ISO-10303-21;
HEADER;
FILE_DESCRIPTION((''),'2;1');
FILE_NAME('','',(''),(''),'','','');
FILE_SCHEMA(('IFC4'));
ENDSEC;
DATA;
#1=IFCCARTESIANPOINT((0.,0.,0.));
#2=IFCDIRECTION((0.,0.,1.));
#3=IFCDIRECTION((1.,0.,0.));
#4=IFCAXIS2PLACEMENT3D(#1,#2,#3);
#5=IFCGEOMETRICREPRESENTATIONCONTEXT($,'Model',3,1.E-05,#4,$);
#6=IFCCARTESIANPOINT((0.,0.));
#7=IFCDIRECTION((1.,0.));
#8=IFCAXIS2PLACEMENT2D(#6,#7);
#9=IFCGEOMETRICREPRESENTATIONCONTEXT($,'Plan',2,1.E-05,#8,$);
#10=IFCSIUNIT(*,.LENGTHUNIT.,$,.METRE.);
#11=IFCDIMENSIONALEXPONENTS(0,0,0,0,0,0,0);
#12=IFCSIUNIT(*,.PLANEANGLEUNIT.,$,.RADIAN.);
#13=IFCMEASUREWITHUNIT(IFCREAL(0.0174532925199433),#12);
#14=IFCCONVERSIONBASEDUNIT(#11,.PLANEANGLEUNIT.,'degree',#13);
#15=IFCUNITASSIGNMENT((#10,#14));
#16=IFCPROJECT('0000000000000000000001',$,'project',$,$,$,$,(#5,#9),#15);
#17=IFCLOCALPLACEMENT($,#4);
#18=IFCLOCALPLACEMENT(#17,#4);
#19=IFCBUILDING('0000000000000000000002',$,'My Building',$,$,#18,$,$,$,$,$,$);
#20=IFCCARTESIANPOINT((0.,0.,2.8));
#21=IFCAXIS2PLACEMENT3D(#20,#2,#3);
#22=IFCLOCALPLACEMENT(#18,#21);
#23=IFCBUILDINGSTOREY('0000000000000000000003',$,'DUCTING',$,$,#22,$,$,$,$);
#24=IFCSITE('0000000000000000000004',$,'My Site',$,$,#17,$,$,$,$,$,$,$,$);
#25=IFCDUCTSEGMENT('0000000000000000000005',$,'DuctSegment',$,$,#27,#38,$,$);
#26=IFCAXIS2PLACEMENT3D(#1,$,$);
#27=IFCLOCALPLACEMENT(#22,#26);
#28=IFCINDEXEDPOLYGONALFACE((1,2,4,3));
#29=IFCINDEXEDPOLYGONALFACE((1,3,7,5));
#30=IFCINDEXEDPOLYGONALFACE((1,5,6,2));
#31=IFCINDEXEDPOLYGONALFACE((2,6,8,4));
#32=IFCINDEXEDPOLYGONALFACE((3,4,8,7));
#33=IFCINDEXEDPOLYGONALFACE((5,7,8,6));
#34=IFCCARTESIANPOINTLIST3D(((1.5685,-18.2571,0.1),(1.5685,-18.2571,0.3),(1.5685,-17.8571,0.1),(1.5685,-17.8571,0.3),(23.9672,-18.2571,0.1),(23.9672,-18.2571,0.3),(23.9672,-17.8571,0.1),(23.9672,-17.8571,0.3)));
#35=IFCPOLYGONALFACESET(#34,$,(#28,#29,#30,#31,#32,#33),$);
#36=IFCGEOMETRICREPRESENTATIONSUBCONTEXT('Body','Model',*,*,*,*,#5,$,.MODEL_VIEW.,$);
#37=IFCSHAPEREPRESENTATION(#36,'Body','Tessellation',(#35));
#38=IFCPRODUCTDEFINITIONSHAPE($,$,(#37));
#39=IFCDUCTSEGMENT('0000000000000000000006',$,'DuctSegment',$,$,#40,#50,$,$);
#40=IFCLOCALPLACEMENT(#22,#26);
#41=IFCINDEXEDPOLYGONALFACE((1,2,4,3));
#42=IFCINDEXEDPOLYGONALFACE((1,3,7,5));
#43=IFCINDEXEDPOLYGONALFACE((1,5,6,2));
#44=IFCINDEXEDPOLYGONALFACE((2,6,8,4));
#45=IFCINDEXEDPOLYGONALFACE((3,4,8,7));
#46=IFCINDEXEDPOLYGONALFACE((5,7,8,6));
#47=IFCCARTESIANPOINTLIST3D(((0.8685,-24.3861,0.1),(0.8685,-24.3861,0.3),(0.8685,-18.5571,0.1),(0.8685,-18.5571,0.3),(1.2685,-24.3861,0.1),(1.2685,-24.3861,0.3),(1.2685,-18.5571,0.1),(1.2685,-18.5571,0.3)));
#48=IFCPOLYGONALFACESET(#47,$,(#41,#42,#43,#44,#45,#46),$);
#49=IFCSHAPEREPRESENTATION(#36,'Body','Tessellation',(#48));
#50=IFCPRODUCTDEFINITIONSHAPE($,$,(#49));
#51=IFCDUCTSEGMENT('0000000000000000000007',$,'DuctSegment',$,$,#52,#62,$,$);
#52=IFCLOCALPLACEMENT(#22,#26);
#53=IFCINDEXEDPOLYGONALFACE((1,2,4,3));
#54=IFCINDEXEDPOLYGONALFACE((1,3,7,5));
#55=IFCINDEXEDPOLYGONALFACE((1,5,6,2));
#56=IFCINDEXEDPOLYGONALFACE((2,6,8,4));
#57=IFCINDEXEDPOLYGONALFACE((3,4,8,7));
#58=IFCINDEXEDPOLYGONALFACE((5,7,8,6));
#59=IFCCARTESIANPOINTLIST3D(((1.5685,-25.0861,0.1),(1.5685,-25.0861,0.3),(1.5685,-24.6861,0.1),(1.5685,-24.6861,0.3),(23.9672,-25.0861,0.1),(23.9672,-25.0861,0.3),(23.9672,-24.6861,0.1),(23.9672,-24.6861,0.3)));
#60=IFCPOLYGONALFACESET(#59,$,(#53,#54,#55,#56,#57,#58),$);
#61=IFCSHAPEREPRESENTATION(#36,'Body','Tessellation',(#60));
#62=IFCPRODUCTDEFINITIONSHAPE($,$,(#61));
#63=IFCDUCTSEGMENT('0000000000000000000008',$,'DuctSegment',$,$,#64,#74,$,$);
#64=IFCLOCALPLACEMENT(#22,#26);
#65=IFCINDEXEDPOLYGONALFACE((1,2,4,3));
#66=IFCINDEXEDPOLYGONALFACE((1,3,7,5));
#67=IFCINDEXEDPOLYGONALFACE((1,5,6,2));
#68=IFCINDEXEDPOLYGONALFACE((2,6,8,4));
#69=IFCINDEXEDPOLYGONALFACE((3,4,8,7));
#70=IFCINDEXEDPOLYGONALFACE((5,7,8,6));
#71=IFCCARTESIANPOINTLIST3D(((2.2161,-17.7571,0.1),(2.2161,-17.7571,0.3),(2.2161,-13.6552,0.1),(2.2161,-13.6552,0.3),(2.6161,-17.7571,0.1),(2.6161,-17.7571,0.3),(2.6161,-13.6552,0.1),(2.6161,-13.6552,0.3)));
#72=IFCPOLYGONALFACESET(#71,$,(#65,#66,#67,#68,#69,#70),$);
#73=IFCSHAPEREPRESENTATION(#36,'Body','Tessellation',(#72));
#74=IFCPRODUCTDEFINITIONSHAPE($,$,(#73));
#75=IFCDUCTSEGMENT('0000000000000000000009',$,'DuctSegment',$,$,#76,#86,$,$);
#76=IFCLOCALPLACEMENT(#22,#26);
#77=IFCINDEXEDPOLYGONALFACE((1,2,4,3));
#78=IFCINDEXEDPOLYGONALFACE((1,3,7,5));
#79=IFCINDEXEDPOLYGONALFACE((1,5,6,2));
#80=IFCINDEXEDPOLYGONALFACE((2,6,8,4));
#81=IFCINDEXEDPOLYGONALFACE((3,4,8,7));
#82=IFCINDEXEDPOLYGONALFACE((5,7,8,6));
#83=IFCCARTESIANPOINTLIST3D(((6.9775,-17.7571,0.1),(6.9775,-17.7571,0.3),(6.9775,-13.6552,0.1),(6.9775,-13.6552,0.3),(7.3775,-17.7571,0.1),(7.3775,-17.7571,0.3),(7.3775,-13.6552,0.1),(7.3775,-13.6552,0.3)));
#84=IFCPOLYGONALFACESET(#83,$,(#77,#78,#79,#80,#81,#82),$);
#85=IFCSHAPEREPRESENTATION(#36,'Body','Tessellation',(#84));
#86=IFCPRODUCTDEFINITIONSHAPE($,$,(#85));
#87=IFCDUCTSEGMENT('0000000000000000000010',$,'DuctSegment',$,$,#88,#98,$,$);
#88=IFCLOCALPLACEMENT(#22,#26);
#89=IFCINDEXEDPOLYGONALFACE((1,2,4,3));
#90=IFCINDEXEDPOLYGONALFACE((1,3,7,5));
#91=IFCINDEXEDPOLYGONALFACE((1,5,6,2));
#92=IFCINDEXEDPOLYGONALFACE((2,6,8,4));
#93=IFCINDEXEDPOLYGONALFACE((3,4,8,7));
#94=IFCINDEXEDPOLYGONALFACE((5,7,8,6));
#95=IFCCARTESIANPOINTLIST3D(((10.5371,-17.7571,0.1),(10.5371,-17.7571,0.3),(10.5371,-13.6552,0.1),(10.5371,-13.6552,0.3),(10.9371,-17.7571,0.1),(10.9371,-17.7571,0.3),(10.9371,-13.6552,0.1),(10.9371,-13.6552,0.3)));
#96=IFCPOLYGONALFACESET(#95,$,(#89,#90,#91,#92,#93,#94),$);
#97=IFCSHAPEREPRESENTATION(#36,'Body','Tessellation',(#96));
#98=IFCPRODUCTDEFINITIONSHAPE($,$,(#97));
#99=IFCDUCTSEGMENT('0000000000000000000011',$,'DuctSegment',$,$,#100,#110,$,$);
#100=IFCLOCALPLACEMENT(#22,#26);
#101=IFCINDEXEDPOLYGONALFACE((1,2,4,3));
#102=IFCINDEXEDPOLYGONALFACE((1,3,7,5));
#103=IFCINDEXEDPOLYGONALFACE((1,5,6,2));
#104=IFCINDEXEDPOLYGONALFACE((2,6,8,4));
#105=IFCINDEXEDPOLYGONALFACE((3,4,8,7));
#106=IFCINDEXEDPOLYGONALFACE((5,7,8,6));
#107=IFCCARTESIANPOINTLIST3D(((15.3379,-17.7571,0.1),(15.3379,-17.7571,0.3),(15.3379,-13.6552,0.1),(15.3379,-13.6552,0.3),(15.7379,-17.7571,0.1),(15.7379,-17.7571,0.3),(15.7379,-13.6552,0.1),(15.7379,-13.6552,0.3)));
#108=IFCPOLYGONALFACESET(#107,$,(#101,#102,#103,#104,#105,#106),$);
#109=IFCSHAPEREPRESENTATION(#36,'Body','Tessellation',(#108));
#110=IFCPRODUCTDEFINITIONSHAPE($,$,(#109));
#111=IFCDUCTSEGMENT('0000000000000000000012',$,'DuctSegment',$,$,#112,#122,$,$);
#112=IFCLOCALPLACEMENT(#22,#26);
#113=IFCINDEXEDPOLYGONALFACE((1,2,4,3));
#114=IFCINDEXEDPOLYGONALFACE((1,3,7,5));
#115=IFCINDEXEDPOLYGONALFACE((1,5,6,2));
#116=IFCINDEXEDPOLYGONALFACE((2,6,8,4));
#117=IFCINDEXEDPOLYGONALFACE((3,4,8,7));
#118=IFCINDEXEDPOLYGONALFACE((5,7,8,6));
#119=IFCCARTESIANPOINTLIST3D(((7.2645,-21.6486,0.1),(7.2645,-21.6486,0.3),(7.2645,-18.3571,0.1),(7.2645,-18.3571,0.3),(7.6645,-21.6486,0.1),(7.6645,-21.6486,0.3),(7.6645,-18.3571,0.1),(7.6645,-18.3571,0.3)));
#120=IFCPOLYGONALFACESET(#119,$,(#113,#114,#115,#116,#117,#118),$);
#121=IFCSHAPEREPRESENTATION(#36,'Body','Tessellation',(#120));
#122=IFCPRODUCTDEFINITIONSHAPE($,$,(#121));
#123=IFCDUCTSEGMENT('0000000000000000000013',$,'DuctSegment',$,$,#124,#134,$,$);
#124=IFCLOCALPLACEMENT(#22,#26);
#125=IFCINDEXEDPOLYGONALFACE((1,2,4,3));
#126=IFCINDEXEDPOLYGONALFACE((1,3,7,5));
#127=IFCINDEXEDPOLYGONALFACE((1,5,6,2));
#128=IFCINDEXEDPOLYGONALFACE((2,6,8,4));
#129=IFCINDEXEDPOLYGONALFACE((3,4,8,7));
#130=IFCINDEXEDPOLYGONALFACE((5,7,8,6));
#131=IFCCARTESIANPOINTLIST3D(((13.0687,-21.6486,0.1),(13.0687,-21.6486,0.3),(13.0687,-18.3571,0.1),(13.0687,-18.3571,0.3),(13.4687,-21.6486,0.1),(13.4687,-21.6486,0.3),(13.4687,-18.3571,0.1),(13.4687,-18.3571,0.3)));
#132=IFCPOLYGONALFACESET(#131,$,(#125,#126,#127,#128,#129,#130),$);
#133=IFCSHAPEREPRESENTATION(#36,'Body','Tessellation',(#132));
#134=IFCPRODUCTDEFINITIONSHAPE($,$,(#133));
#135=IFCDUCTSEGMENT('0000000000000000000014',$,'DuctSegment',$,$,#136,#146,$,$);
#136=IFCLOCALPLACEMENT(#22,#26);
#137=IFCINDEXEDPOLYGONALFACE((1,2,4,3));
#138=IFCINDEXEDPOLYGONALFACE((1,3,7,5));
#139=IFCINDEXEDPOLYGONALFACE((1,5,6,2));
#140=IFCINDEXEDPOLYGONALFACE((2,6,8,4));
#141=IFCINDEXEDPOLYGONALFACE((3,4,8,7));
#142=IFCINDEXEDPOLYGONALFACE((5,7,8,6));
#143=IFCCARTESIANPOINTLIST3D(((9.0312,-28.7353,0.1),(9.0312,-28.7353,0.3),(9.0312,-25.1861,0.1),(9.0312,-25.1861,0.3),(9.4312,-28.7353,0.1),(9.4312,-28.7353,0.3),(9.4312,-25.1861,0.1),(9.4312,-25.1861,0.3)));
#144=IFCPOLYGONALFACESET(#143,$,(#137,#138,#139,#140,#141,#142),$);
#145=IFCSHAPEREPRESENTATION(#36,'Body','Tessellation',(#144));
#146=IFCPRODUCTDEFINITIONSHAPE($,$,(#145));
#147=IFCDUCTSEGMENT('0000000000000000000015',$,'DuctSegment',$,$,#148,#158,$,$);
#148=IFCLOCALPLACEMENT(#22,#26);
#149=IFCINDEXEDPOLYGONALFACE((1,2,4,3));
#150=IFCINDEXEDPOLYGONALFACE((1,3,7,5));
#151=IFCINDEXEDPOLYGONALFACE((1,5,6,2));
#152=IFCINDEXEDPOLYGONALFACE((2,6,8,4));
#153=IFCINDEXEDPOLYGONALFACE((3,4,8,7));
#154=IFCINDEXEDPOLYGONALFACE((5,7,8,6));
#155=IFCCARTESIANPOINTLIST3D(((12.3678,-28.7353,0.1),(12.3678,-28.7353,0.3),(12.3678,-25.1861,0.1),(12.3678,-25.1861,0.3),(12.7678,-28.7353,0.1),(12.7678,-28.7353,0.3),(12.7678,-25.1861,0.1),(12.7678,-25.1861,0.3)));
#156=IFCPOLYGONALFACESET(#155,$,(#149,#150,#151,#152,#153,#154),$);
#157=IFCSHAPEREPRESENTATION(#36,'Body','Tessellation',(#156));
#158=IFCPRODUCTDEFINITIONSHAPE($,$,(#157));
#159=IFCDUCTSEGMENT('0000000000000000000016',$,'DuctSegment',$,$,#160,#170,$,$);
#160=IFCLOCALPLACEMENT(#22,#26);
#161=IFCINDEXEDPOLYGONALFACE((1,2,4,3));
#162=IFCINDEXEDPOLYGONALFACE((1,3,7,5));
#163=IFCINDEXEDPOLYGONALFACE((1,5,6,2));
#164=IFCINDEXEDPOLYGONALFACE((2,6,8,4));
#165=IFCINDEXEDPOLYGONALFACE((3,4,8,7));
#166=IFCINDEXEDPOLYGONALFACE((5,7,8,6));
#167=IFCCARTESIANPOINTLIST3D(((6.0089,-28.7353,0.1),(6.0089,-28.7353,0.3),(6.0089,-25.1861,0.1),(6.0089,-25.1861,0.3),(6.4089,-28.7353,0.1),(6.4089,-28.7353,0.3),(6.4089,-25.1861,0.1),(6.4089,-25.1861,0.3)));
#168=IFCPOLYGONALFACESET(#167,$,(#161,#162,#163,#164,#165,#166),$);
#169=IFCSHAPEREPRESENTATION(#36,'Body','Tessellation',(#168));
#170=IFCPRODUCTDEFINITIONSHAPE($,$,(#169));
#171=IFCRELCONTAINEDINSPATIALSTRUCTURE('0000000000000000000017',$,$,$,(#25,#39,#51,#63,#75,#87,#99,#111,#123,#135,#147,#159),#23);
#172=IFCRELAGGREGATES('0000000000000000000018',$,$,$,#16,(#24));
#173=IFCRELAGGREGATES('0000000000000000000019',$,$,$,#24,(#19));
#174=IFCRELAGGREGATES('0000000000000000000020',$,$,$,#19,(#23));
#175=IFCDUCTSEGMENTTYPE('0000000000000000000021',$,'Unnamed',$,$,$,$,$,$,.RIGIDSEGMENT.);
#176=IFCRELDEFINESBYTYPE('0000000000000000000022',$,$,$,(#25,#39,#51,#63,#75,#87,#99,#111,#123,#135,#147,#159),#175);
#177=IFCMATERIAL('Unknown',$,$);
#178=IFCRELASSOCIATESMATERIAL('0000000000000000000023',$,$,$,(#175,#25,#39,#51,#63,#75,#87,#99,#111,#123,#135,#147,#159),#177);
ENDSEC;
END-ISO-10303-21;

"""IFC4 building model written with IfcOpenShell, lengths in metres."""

from ifc_helpers import new_model, entity, si_unit, converted_unit, frame, origin_with_axes, origin_2d_with_axis, place, context, subcontext, project, spatial, rectangle, extrude, material, material_profile, profile_set, profile_usage, type_object, element, save


model = new_model("IFC4")

# Units and contexts
model_context = context("Model", 3, precision=1e-05, world=origin_with_axes())
plan_context = context("Plan", 2, precision=1e-05, world=origin_2d_with_axis())
body_context = subcontext(model_context, "Body", "Model", "MODEL_VIEW")
ifc_project = project(units=[si_unit("LENGTHUNIT", "METRE"), converted_unit("PLANEANGLEUNIT", "degree", entity("IfcReal", 0.0174532925199433), si_unit("PLANEANGLEUNIT", "RADIAN"), dimensions=[0, 0, 0, 0, 0, 0, 0])], contexts=[model_context, plan_context])

# Site, building, storey
site_placement = place(None, origin_with_axes())
site = spatial("IfcSite", under=ifc_project, at=site_placement, Name="My Site")
building_placement = place(site_placement, origin_with_axes())
building = spatial("IfcBuilding", under=site, at=building_placement, Name="My Building")
storey_placement = place(building_placement, frame((0.0, 0.0, 2.8), z_axis=(0.0, 0.0, 1.0), x_axis=(1.0, 0.0, 0.0)))
storey = spatial("IfcBuildingStorey", under=building, at=storey_placement, Name="DUCTING")

# Duct segments
ifc_material = material(Name="Unknown")
ifc_material_profile_1 = material_profile(ifc_material, rectangle(XDim=0.4, YDim=0.2))
ifc_profile_set_1 = profile_set([ifc_material_profile_1])
ifc_profile_usage_1 = profile_usage(ifc_profile_set_1, cardinal=5)
duct_segment_type = type_object("IfcDuctSegmentType", Name="Unnamed", PredefinedType="RIGIDSEGMENT", material=ifc_profile_set_1)
duct_segment_1_placement = place(storey_placement, frame((1.5685, -18.0571, 0.2), z_axis=(1.0, 0.0, 0.0), x_axis=(0.0, 1.0, 0.0)))
element("IfcDuctSegment", 1, at=duct_segment_1_placement, inside=storey, type_object=duct_segment_type, material=ifc_profile_usage_1, Name="DuctSegment", context=body_context, shape_type="SweptSolid", body=[
    extrude(rectangle(XDim=0.4, YDim=0.2), origin_with_axes(), (0.0, 0.0, 1.0), 22.3987),
])
ifc_profile_usage_2 = profile_usage(ifc_profile_set_1, cardinal=5)
duct_segment_2_placement = place(storey_placement, frame((1.0685, -18.5571, 0.2), z_axis=(0.0, -1.0, 0.0), x_axis=(1.0, 0.0, 0.0)))
element("IfcDuctSegment", 2, at=duct_segment_2_placement, inside=storey, type_object=duct_segment_type, material=ifc_profile_usage_2, Name="DuctSegment", context=body_context, shape_type="SweptSolid", body=[
    extrude(rectangle(XDim=0.4, YDim=0.2), origin_with_axes(), (0.0, 0.0, 1.0), 5.8291),
])
ifc_profile_usage_3 = profile_usage(ifc_profile_set_1, cardinal=5)
duct_segment_3_placement = place(storey_placement, frame((1.5685, -24.8861, 0.2), z_axis=(1.0, 0.0, 0.0), x_axis=(0.0, 1.0, 0.0)))
element("IfcDuctSegment", 3, at=duct_segment_3_placement, inside=storey, type_object=duct_segment_type, material=ifc_profile_usage_3, Name="DuctSegment", context=body_context, shape_type="SweptSolid", body=[
    extrude(rectangle(XDim=0.4, YDim=0.2), origin_with_axes(), (0.0, 0.0, 1.0), 22.3987),
])
ifc_profile_usage_4 = profile_usage(ifc_profile_set_1, cardinal=5)
duct_segment_4_placement = place(storey_placement, frame((2.4161, -17.7571, 0.2), z_axis=(0.0, 1.0, 0.0), x_axis=(-1.0, 0.0, 0.0)))
element("IfcDuctSegment", 4, at=duct_segment_4_placement, inside=storey, type_object=duct_segment_type, material=ifc_profile_usage_4, Name="DuctSegment", context=body_context, shape_type="SweptSolid", body=[
    extrude(rectangle(XDim=0.4, YDim=0.2), origin_with_axes(), (0.0, 0.0, 1.0), 4.1019),
])
ifc_profile_usage_5 = profile_usage(ifc_profile_set_1, cardinal=5)
duct_segment_5_placement = place(storey_placement, frame((7.1775, -17.7571, 0.2), z_axis=(0.0, 1.0, 0.0), x_axis=(-1.0, 0.0, 0.0)))
element("IfcDuctSegment", 5, at=duct_segment_5_placement, inside=storey, type_object=duct_segment_type, material=ifc_profile_usage_5, Name="DuctSegment", context=body_context, shape_type="SweptSolid", body=[
    extrude(rectangle(XDim=0.4, YDim=0.2), origin_with_axes(), (0.0, 0.0, 1.0), 4.1019),
])
ifc_profile_usage_6 = profile_usage(ifc_profile_set_1, cardinal=5)
duct_segment_6_placement = place(storey_placement, frame((10.7371, -17.7571, 0.2), z_axis=(0.0, 1.0, 0.0), x_axis=(-1.0, 0.0, 0.0)))
element("IfcDuctSegment", 6, at=duct_segment_6_placement, inside=storey, type_object=duct_segment_type, material=ifc_profile_usage_6, Name="DuctSegment", context=body_context, shape_type="SweptSolid", body=[
    extrude(rectangle(XDim=0.4, YDim=0.2), origin_with_axes(), (0.0, 0.0, 1.0), 4.1019),
])
ifc_profile_usage_7 = profile_usage(ifc_profile_set_1, cardinal=5)
duct_segment_7_placement = place(storey_placement, frame((15.5379, -17.7571, 0.2), z_axis=(0.0, 1.0, 0.0), x_axis=(-1.0, 0.0, 0.0)))
element("IfcDuctSegment", 7, at=duct_segment_7_placement, inside=storey, type_object=duct_segment_type, material=ifc_profile_usage_7, Name="DuctSegment", context=body_context, shape_type="SweptSolid", body=[
    extrude(rectangle(XDim=0.4, YDim=0.2), origin_with_axes(), (0.0, 0.0, 1.0), 4.1019),
])
ifc_profile_usage_8 = profile_usage(ifc_profile_set_1, cardinal=5)
duct_segment_8_placement = place(storey_placement, frame((7.4645, -18.3571, 0.2), z_axis=(0.0, -1.0, 0.0), x_axis=(1.0, 0.0, 0.0)))
element("IfcDuctSegment", 8, at=duct_segment_8_placement, inside=storey, type_object=duct_segment_type, material=ifc_profile_usage_8, Name="DuctSegment", context=body_context, shape_type="SweptSolid", body=[
    extrude(rectangle(XDim=0.4, YDim=0.2), origin_with_axes(), (0.0, 0.0, 1.0), 3.2916),
])
ifc_profile_usage_9 = profile_usage(ifc_profile_set_1, cardinal=5)
duct_segment_9_placement = place(storey_placement, frame((13.2687, -18.3571, 0.2), z_axis=(0.0, -1.0, 0.0), x_axis=(1.0, 0.0, 0.0)))
element("IfcDuctSegment", 9, at=duct_segment_9_placement, inside=storey, type_object=duct_segment_type, material=ifc_profile_usage_9, Name="DuctSegment", context=body_context, shape_type="SweptSolid", body=[
    extrude(rectangle(XDim=0.4, YDim=0.2), origin_with_axes(), (0.0, 0.0, 1.0), 3.2916),
])
ifc_profile_usage_10 = profile_usage(ifc_profile_set_1, cardinal=5)
duct_segment_10_placement = place(storey_placement, frame((9.2312, -25.1861, 0.2), z_axis=(0.0, -1.0, 0.0), x_axis=(1.0, 0.0, 0.0)))
element("IfcDuctSegment", 10, at=duct_segment_10_placement, inside=storey, type_object=duct_segment_type, material=ifc_profile_usage_10, Name="DuctSegment", context=body_context, shape_type="SweptSolid", body=[
    extrude(rectangle(XDim=0.4, YDim=0.2), origin_with_axes(), (0.0, 0.0, 1.0), 3.5492),
])
ifc_profile_usage_11 = profile_usage(ifc_profile_set_1, cardinal=5)
duct_segment_11_placement = place(storey_placement, frame((12.5678, -25.1861, 0.2), z_axis=(0.0, -1.0, 0.0), x_axis=(1.0, 0.0, 0.0)))
element("IfcDuctSegment", 11, at=duct_segment_11_placement, inside=storey, type_object=duct_segment_type, material=ifc_profile_usage_11, Name="DuctSegment", context=body_context, shape_type="SweptSolid", body=[
    extrude(rectangle(XDim=0.4, YDim=0.2), origin_with_axes(), (0.0, 0.0, 1.0), 3.5492),
])
ifc_profile_usage_12 = profile_usage(ifc_profile_set_1, cardinal=5)
duct_segment_12_placement = place(storey_placement, frame((6.2089, -25.1861, 0.2), z_axis=(0.0, -1.0, 0.0), x_axis=(1.0, 0.0, 0.0)))
element("IfcDuctSegment", 12, at=duct_segment_12_placement, inside=storey, type_object=duct_segment_type, material=ifc_profile_usage_12, Name="DuctSegment", context=body_context, shape_type="SweptSolid", body=[
    extrude(rectangle(XDim=0.4, YDim=0.2), origin_with_axes(), (0.0, 0.0, 1.0), 3.5492),
])

save(model, "model.ifc")
